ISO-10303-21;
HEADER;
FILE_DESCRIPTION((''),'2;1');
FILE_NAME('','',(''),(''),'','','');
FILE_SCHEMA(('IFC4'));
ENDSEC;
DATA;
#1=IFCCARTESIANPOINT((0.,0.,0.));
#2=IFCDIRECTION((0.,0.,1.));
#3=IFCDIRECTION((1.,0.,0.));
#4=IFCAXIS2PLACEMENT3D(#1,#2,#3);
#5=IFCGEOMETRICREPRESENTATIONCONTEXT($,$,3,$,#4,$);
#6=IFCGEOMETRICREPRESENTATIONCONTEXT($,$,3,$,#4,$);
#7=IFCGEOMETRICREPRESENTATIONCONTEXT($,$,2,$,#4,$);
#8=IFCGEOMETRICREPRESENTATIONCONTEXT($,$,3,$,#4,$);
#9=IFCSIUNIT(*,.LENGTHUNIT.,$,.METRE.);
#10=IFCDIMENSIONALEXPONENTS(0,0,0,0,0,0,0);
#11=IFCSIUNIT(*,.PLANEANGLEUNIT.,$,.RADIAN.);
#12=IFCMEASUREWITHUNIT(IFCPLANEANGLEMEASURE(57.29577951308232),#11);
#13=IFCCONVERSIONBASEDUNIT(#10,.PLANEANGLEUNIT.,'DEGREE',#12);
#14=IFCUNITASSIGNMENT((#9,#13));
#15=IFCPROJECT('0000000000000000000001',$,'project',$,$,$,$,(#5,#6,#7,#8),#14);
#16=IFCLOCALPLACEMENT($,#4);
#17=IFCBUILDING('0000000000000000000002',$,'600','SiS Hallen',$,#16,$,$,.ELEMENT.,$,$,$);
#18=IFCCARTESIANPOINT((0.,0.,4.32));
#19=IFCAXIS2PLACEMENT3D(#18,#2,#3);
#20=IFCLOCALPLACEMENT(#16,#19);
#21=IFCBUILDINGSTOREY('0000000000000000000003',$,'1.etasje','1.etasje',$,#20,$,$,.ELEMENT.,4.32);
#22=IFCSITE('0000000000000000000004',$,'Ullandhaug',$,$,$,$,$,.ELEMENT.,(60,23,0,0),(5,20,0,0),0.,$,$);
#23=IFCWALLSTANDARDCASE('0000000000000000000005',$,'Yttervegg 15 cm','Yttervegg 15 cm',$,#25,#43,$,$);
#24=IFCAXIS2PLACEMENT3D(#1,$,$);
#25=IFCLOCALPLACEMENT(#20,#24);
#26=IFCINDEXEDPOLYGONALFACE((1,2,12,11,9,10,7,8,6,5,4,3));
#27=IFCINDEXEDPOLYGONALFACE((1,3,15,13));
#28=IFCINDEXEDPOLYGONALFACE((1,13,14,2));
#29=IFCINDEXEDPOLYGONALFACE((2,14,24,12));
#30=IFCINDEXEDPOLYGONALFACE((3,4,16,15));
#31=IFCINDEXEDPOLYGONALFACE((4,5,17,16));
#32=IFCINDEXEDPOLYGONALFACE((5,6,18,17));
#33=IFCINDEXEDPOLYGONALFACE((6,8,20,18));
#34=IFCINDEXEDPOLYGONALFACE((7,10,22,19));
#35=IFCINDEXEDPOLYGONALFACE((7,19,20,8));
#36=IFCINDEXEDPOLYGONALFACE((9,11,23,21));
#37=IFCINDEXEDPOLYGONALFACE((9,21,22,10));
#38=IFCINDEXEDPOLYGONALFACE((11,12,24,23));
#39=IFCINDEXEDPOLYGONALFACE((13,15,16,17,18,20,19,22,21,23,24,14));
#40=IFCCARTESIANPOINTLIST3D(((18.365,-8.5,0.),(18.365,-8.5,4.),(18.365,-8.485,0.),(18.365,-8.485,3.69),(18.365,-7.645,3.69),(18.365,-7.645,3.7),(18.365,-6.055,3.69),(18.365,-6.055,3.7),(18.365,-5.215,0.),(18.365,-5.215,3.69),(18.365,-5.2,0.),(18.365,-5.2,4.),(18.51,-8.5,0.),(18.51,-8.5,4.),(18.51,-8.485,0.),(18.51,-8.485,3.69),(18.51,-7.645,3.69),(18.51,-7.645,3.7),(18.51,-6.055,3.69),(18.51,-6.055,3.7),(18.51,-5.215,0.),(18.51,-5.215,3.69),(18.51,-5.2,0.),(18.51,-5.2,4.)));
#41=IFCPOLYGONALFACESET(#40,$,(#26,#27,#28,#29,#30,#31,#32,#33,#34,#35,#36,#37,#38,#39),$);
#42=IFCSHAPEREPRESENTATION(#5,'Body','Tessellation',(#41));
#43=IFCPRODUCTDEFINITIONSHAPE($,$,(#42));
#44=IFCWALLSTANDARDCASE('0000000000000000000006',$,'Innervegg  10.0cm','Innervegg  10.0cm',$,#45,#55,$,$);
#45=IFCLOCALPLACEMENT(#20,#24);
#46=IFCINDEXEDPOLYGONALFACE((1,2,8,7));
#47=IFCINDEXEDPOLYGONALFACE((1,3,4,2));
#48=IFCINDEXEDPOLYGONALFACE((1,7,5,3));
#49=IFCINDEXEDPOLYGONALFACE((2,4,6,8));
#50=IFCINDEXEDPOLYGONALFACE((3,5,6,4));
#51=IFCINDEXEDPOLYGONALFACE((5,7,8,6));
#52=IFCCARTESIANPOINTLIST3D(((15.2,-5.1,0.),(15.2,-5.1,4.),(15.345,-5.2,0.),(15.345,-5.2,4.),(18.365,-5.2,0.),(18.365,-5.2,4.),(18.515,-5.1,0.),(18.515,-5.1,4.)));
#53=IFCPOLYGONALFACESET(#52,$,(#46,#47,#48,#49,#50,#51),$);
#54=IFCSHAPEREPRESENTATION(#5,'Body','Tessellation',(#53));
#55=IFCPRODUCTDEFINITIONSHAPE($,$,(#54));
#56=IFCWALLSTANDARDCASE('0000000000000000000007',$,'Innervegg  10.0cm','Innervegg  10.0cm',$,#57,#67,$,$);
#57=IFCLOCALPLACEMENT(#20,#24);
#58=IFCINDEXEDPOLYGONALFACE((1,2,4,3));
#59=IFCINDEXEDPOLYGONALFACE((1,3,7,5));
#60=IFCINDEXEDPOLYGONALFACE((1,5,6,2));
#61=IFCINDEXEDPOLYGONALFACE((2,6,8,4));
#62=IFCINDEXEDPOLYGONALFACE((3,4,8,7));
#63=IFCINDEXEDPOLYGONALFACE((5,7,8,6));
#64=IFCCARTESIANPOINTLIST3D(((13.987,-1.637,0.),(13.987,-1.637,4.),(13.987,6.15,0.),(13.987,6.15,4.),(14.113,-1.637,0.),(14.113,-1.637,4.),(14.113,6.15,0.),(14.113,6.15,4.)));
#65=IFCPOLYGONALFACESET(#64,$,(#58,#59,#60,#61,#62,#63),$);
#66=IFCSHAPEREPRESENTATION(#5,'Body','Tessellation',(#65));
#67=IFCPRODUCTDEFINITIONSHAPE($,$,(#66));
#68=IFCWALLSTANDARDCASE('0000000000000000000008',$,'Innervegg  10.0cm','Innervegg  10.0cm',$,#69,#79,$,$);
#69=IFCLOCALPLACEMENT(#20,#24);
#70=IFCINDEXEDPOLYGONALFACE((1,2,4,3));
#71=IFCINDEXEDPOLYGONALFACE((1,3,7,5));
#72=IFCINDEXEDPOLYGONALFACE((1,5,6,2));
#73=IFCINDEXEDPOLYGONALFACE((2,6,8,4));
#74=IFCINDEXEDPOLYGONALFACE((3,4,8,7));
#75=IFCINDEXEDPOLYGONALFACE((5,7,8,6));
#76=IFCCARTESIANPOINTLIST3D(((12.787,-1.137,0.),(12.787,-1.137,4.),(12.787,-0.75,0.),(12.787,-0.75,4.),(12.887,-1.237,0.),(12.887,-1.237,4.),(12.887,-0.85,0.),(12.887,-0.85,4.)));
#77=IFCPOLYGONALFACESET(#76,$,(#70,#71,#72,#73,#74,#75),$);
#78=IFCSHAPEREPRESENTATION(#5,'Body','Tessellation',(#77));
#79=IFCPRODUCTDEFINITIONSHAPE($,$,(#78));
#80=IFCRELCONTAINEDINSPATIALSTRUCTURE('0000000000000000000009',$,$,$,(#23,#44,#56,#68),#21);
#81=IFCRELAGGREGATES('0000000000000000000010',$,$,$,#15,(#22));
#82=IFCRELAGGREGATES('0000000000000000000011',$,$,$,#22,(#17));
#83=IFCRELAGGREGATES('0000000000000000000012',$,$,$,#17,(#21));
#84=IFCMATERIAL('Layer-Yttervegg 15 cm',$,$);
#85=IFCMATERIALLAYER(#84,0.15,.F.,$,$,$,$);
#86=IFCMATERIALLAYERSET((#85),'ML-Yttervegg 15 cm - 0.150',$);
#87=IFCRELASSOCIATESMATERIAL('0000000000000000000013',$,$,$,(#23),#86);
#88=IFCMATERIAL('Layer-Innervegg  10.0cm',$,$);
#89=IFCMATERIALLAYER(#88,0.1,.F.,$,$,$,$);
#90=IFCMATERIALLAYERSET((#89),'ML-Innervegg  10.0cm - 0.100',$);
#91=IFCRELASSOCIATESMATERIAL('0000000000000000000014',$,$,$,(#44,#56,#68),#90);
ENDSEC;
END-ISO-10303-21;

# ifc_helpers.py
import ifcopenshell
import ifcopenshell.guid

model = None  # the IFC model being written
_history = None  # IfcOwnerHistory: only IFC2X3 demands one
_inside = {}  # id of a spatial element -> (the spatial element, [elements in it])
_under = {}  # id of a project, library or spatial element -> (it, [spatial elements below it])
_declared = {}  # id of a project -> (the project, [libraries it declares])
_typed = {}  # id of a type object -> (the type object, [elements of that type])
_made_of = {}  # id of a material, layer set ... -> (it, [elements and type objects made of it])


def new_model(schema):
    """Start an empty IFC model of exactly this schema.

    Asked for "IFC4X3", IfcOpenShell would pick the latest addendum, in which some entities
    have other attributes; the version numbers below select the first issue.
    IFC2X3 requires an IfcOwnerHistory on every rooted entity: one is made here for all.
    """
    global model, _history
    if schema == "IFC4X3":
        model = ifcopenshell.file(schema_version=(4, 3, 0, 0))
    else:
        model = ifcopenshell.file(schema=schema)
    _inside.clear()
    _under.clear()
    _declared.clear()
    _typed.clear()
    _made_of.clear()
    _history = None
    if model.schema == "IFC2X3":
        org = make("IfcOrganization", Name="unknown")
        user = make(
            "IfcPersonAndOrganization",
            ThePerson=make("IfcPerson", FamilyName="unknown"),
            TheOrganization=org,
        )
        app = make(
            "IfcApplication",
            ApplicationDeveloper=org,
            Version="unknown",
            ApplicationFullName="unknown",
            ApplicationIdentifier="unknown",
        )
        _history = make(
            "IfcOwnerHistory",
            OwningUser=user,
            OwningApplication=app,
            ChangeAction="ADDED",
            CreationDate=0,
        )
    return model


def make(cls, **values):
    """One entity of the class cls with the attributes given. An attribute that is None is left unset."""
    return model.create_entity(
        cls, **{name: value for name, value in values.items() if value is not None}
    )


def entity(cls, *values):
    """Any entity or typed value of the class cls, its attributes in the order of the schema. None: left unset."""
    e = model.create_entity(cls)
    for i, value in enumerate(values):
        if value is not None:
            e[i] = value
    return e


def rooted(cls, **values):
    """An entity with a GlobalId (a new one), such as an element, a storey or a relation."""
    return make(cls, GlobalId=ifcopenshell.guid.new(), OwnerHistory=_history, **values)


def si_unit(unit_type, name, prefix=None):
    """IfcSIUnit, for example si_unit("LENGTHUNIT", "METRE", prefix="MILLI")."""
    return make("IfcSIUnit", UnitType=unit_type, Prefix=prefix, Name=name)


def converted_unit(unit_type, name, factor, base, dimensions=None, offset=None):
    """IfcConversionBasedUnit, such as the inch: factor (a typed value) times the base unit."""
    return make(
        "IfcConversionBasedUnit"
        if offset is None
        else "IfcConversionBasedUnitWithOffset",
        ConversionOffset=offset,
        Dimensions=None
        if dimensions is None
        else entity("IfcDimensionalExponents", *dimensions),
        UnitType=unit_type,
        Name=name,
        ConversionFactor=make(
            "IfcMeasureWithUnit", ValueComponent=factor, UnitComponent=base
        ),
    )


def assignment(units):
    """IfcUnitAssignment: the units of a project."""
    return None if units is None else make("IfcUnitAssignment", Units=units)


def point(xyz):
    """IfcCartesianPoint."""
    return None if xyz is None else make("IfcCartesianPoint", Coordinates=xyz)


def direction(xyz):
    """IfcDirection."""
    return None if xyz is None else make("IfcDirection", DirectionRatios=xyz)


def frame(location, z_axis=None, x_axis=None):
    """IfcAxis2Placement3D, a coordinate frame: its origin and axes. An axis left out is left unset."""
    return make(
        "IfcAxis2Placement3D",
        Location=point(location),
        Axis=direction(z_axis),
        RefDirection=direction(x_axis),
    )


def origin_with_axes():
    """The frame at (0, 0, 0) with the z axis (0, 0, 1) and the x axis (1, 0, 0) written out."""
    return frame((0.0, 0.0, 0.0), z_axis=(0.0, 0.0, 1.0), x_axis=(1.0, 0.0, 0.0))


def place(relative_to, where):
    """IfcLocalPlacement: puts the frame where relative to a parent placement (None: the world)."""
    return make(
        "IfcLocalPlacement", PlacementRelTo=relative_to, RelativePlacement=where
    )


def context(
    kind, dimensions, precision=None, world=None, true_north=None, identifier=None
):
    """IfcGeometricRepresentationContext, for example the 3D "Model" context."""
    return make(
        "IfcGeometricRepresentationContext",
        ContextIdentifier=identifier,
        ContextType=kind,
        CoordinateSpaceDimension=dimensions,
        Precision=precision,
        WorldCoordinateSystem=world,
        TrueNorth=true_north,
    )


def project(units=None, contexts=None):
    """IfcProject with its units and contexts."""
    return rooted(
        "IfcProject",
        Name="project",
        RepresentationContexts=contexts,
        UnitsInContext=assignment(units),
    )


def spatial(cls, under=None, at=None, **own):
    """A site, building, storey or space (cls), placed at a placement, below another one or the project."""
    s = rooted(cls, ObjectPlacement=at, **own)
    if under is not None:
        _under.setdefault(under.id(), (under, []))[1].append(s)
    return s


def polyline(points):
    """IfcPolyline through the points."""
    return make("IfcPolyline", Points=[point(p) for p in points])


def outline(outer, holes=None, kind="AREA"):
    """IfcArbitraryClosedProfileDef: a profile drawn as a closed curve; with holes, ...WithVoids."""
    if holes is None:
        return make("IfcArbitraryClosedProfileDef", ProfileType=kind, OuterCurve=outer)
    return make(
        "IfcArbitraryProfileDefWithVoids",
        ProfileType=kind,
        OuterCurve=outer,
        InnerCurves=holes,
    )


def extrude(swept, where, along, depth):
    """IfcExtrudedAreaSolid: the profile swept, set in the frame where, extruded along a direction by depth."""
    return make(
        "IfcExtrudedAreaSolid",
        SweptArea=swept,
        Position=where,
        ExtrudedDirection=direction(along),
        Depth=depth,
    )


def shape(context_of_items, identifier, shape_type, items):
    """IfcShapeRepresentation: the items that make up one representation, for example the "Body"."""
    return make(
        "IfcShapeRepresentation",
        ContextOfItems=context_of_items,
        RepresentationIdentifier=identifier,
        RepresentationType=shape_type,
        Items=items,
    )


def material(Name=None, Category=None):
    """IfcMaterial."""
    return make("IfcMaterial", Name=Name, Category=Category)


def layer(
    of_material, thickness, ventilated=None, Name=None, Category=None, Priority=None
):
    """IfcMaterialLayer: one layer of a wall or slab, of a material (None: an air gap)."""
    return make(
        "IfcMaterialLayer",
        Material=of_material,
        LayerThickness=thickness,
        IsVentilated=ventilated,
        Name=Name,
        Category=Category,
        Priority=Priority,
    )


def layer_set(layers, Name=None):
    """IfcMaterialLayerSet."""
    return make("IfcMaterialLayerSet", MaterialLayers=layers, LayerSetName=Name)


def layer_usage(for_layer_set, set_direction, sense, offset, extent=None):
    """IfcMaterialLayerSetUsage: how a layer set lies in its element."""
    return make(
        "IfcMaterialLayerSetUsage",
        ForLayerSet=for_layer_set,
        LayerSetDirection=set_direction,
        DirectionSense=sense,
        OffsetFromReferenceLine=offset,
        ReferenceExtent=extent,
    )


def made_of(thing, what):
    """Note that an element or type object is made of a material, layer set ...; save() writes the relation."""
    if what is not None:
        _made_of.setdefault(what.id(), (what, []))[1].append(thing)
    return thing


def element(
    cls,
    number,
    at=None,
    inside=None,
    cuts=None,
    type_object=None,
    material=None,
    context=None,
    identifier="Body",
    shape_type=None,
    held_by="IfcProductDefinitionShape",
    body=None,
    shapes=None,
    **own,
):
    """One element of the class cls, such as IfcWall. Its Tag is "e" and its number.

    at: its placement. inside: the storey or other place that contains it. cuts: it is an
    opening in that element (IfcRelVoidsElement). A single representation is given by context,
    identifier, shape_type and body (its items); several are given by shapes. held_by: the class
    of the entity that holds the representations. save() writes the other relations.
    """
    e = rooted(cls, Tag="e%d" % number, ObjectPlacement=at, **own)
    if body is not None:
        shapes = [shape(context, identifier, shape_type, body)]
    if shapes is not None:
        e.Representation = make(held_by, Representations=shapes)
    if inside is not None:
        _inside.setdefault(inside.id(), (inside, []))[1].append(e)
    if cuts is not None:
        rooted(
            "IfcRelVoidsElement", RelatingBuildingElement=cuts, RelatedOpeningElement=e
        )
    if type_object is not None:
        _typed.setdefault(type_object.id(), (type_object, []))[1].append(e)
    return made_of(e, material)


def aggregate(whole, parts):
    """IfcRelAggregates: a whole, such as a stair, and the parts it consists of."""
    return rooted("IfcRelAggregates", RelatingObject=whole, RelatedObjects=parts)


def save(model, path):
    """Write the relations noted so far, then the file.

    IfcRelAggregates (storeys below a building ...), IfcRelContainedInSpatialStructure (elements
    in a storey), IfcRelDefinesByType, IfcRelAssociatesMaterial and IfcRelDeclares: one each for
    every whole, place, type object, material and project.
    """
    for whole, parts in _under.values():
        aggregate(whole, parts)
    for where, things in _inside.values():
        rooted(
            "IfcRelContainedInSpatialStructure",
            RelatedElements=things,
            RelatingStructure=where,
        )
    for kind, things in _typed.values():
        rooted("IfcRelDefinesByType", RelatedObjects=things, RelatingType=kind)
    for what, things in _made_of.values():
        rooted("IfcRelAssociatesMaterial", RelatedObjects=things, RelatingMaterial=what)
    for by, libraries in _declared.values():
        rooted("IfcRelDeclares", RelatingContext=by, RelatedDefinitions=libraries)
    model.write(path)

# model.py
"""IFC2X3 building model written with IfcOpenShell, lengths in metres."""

from ifc_helpers import new_model, entity, si_unit, converted_unit, frame, origin_with_axes, place, context, project, spatial, polyline, outline, extrude, material, layer, layer_set, layer_usage, element, save


model = new_model("IFC2X3")

# Units and contexts
context_of_model_1 = context(None, 3, world=origin_with_axes())
context_of_model_2 = context(None, 3, world=origin_with_axes())
context_of_model_3 = context(None, 2, world=origin_with_axes())
context_of_model_4 = context(None, 3, world=origin_with_axes())
ifc_project = project(units=[si_unit("LENGTHUNIT", "METRE"), converted_unit("PLANEANGLEUNIT", "DEGREE", entity("IfcPlaneAngleMeasure", 57.29577951308232), si_unit("PLANEANGLEUNIT", "RADIAN"), dimensions=[0, 0, 0, 0, 0, 0, 0])], contexts=[context_of_model_1, context_of_model_2, context_of_model_3, context_of_model_4])

# Site, building, storey
site = spatial("IfcSite", under=ifc_project, Name="Ullandhaug", CompositionType="ELEMENT", RefLatitude=(60, 23, 0, 0), RefLongitude=(5, 20, 0, 0), RefElevation=0.0)
building_placement = place(None, origin_with_axes())
building = spatial("IfcBuilding", under=site, at=building_placement, Name="600", Description="SiS Hallen", CompositionType="ELEMENT")
storey_placement = place(building_placement, frame((0.0, 0.0, 4.32), z_axis=(0.0, 0.0, 1.0), x_axis=(1.0, 0.0, 0.0)))
storey = spatial("IfcBuildingStorey", under=building, at=storey_placement, Name="1.etasje", Description="1.etasje", CompositionType="ELEMENT", Elevation=4.32)

# Shared definitions
ifc_material_1 = material(Name="Layer-Yttervegg 15 cm")
ifc_layer_1 = layer(ifc_material_1, 0.15, ventilated=False)
ifc_layer_set_1 = layer_set([ifc_layer_1], Name="ML-Yttervegg 15 cm - 0.150")
ifc_layer_usage_1 = layer_usage(ifc_layer_set_1, "AXIS2", "POSITIVE", 0.0)
ifc_material_2 = material(Name="Layer-Innervegg  10.0cm")
ifc_layer_2 = layer(ifc_material_2, 0.1, ventilated=False)
ifc_layer_set_2 = layer_set([ifc_layer_2], Name="ML-Innervegg  10.0cm - 0.100")
ifc_layer_usage_2 = layer_usage(ifc_layer_set_2, "AXIS2", "POSITIVE", 0.0)

# Wall, openings
wall_1_placement = place(storey_placement, frame((18.51, -8.5, 0.0), z_axis=(0.0, 0.0, 1.0), x_axis=(0.0, 1.0, 0.0)))
wall_1 = element("IfcWallStandardCase", 1, at=wall_1_placement, inside=storey, material=ifc_layer_usage_1, Name="Yttervegg 15 cm", Description="Yttervegg 15 cm", context=context_of_model_1, shape_type="SweptSolid", body=[
    extrude(outline(polyline([(0.0, 0.0), (3.3, 0.0), (3.3, 0.145), (0.0, 0.145), (0.0, 0.0)])), frame((0.0, 0.0, 0.0), z_axis=(0.0, 0.0, 1.0), x_axis=(1.0, 0.0, 0.0)), (0.0, 0.0, 1.0), 4.0),
])
opening_1_placement = place(wall_1_placement, frame((0.855, 0.145, 0.0), z_axis=(0.0, 0.0, 1.0), x_axis=(1.0, 0.0, 0.0)))
element("IfcOpeningElement", 2, at=opening_1_placement, cuts=wall_1, context=context_of_model_1, shape_type="SweptSolid", body=[
    extrude(outline(polyline([(0.0, 0.0), (2.1, 0.0), (2.1, 1.59), (0.0, 1.59), (0.0, 0.0)])), frame((0.0, 0.0, 0.0), z_axis=(0.0, 1.0, 0.0), x_axis=(0.0, 0.0, 1.0)), (0.0, 0.0, -1.0), 0.15),
])
opening_2_placement = place(wall_1_placement, frame((0.015, 0.145, 0.0), z_axis=(0.0, 0.0, 1.0), x_axis=(1.0, 0.0, 0.0)))
element("IfcOpeningElement", 3, at=opening_2_placement, cuts=wall_1, context=context_of_model_1, shape_type="SweptSolid", body=[
    extrude(outline(polyline([(0.0, 0.0), (3.69, 0.0), (3.69, 0.84), (0.0, 0.84), (0.0, 0.0)])), frame((0.0, 0.0, 0.0), z_axis=(0.0, 1.0, 0.0), x_axis=(0.0, 0.0, 1.0)), (0.0, 0.0, -1.0), 0.15),
])
opening_3_placement = place(wall_1_placement, frame((2.445, 0.145, 0.0), z_axis=(0.0, 0.0, 1.0), x_axis=(1.0, 0.0, 0.0)))
element("IfcOpeningElement", 4, at=opening_3_placement, cuts=wall_1, context=context_of_model_1, shape_type="SweptSolid", body=[
    extrude(outline(polyline([(0.0, 0.0), (3.69, 0.0), (3.69, 0.84), (0.0, 0.84), (0.0, 0.0)])), frame((0.0, 0.0, 0.0), z_axis=(0.0, 1.0, 0.0), x_axis=(0.0, 0.0, 1.0)), (0.0, 0.0, -1.0), 0.15),
])
opening_4_placement = place(wall_1_placement, frame((0.855, 0.145, 2.1), z_axis=(0.0, 0.0, 1.0), x_axis=(1.0, 0.0, 0.0)))
element("IfcOpeningElement", 5, at=opening_4_placement, cuts=wall_1, context=context_of_model_1, shape_type="SweptSolid", body=[
    extrude(outline(polyline([(0.0, 0.0), (1.6, 0.0), (1.6, 1.59), (0.0, 1.59), (0.0, 0.0)])), frame((0.0, 0.0, 0.0), z_axis=(0.0, 1.0, 0.0), x_axis=(0.0, 0.0, 1.0)), (0.0, 0.0, -1.0), 0.15),
])

# Walls
wall_2_placement = place(storey_placement, frame((18.515, -5.1, 0.0), z_axis=(0.0, 0.0, 1.0), x_axis=(-1.0, 0.0, 0.0)))
element("IfcWallStandardCase", 6, at=wall_2_placement, inside=storey, material=ifc_layer_usage_2, Name="Innervegg  10.0cm", Description="Innervegg  10.0cm", context=context_of_model_1, shape_type="SweptSolid", body=[
    extrude(outline(polyline([(0.0, 0.0), (3.315, 0.0), (3.17, 0.1), (0.15, 0.1), (0.0, 0.0)])), frame((0.0, 0.0, 0.0), z_axis=(0.0, 0.0, 1.0), x_axis=(1.0, 0.0, 0.0)), (0.0, 0.0, 1.0), 4.0),
])
wall_3_placement = place(storey_placement, frame((14.113, -1.637, 0.0), z_axis=(0.0, 0.0, 1.0), x_axis=(0.0, 1.0, 0.0)))
element("IfcWallStandardCase", 7, at=wall_3_placement, inside=storey, material=ifc_layer_usage_2, Name="Innervegg  10.0cm", Description="Innervegg  10.0cm", context=context_of_model_1, shape_type="SweptSolid", body=[
    extrude(outline(polyline([(0.0, 0.0), (7.787, 0.0), (7.787, 0.126), (0.0, 0.126), (0.0, 0.0)])), frame((0.0, 0.0, 0.0), z_axis=(0.0, 0.0, 1.0), x_axis=(1.0, 0.0, 0.0)), (0.0, 0.0, 1.0), 4.0),
])
wall_4_placement = place(storey_placement, frame((12.887, -1.237, 0.0), z_axis=(0.0, 0.0, 1.0), x_axis=(0.0, 1.0, 0.0)))
element("IfcWallStandardCase", 8, at=wall_4_placement, inside=storey, material=ifc_layer_usage_2, Name="Innervegg  10.0cm", Description="Innervegg  10.0cm", context=context_of_model_1, shape_type="SweptSolid", body=[
    extrude(outline(polyline([(0.0, 0.0), (0.387, 0.0), (0.487, 0.1), (0.1, 0.1), (0.0, 0.0)])), frame((0.0, 0.0, 0.0), z_axis=(0.0, 0.0, 1.0), x_axis=(1.0, 0.0, 0.0)), (0.0, 0.0, 1.0), 4.0),
])

save(model, "model.ifc")
